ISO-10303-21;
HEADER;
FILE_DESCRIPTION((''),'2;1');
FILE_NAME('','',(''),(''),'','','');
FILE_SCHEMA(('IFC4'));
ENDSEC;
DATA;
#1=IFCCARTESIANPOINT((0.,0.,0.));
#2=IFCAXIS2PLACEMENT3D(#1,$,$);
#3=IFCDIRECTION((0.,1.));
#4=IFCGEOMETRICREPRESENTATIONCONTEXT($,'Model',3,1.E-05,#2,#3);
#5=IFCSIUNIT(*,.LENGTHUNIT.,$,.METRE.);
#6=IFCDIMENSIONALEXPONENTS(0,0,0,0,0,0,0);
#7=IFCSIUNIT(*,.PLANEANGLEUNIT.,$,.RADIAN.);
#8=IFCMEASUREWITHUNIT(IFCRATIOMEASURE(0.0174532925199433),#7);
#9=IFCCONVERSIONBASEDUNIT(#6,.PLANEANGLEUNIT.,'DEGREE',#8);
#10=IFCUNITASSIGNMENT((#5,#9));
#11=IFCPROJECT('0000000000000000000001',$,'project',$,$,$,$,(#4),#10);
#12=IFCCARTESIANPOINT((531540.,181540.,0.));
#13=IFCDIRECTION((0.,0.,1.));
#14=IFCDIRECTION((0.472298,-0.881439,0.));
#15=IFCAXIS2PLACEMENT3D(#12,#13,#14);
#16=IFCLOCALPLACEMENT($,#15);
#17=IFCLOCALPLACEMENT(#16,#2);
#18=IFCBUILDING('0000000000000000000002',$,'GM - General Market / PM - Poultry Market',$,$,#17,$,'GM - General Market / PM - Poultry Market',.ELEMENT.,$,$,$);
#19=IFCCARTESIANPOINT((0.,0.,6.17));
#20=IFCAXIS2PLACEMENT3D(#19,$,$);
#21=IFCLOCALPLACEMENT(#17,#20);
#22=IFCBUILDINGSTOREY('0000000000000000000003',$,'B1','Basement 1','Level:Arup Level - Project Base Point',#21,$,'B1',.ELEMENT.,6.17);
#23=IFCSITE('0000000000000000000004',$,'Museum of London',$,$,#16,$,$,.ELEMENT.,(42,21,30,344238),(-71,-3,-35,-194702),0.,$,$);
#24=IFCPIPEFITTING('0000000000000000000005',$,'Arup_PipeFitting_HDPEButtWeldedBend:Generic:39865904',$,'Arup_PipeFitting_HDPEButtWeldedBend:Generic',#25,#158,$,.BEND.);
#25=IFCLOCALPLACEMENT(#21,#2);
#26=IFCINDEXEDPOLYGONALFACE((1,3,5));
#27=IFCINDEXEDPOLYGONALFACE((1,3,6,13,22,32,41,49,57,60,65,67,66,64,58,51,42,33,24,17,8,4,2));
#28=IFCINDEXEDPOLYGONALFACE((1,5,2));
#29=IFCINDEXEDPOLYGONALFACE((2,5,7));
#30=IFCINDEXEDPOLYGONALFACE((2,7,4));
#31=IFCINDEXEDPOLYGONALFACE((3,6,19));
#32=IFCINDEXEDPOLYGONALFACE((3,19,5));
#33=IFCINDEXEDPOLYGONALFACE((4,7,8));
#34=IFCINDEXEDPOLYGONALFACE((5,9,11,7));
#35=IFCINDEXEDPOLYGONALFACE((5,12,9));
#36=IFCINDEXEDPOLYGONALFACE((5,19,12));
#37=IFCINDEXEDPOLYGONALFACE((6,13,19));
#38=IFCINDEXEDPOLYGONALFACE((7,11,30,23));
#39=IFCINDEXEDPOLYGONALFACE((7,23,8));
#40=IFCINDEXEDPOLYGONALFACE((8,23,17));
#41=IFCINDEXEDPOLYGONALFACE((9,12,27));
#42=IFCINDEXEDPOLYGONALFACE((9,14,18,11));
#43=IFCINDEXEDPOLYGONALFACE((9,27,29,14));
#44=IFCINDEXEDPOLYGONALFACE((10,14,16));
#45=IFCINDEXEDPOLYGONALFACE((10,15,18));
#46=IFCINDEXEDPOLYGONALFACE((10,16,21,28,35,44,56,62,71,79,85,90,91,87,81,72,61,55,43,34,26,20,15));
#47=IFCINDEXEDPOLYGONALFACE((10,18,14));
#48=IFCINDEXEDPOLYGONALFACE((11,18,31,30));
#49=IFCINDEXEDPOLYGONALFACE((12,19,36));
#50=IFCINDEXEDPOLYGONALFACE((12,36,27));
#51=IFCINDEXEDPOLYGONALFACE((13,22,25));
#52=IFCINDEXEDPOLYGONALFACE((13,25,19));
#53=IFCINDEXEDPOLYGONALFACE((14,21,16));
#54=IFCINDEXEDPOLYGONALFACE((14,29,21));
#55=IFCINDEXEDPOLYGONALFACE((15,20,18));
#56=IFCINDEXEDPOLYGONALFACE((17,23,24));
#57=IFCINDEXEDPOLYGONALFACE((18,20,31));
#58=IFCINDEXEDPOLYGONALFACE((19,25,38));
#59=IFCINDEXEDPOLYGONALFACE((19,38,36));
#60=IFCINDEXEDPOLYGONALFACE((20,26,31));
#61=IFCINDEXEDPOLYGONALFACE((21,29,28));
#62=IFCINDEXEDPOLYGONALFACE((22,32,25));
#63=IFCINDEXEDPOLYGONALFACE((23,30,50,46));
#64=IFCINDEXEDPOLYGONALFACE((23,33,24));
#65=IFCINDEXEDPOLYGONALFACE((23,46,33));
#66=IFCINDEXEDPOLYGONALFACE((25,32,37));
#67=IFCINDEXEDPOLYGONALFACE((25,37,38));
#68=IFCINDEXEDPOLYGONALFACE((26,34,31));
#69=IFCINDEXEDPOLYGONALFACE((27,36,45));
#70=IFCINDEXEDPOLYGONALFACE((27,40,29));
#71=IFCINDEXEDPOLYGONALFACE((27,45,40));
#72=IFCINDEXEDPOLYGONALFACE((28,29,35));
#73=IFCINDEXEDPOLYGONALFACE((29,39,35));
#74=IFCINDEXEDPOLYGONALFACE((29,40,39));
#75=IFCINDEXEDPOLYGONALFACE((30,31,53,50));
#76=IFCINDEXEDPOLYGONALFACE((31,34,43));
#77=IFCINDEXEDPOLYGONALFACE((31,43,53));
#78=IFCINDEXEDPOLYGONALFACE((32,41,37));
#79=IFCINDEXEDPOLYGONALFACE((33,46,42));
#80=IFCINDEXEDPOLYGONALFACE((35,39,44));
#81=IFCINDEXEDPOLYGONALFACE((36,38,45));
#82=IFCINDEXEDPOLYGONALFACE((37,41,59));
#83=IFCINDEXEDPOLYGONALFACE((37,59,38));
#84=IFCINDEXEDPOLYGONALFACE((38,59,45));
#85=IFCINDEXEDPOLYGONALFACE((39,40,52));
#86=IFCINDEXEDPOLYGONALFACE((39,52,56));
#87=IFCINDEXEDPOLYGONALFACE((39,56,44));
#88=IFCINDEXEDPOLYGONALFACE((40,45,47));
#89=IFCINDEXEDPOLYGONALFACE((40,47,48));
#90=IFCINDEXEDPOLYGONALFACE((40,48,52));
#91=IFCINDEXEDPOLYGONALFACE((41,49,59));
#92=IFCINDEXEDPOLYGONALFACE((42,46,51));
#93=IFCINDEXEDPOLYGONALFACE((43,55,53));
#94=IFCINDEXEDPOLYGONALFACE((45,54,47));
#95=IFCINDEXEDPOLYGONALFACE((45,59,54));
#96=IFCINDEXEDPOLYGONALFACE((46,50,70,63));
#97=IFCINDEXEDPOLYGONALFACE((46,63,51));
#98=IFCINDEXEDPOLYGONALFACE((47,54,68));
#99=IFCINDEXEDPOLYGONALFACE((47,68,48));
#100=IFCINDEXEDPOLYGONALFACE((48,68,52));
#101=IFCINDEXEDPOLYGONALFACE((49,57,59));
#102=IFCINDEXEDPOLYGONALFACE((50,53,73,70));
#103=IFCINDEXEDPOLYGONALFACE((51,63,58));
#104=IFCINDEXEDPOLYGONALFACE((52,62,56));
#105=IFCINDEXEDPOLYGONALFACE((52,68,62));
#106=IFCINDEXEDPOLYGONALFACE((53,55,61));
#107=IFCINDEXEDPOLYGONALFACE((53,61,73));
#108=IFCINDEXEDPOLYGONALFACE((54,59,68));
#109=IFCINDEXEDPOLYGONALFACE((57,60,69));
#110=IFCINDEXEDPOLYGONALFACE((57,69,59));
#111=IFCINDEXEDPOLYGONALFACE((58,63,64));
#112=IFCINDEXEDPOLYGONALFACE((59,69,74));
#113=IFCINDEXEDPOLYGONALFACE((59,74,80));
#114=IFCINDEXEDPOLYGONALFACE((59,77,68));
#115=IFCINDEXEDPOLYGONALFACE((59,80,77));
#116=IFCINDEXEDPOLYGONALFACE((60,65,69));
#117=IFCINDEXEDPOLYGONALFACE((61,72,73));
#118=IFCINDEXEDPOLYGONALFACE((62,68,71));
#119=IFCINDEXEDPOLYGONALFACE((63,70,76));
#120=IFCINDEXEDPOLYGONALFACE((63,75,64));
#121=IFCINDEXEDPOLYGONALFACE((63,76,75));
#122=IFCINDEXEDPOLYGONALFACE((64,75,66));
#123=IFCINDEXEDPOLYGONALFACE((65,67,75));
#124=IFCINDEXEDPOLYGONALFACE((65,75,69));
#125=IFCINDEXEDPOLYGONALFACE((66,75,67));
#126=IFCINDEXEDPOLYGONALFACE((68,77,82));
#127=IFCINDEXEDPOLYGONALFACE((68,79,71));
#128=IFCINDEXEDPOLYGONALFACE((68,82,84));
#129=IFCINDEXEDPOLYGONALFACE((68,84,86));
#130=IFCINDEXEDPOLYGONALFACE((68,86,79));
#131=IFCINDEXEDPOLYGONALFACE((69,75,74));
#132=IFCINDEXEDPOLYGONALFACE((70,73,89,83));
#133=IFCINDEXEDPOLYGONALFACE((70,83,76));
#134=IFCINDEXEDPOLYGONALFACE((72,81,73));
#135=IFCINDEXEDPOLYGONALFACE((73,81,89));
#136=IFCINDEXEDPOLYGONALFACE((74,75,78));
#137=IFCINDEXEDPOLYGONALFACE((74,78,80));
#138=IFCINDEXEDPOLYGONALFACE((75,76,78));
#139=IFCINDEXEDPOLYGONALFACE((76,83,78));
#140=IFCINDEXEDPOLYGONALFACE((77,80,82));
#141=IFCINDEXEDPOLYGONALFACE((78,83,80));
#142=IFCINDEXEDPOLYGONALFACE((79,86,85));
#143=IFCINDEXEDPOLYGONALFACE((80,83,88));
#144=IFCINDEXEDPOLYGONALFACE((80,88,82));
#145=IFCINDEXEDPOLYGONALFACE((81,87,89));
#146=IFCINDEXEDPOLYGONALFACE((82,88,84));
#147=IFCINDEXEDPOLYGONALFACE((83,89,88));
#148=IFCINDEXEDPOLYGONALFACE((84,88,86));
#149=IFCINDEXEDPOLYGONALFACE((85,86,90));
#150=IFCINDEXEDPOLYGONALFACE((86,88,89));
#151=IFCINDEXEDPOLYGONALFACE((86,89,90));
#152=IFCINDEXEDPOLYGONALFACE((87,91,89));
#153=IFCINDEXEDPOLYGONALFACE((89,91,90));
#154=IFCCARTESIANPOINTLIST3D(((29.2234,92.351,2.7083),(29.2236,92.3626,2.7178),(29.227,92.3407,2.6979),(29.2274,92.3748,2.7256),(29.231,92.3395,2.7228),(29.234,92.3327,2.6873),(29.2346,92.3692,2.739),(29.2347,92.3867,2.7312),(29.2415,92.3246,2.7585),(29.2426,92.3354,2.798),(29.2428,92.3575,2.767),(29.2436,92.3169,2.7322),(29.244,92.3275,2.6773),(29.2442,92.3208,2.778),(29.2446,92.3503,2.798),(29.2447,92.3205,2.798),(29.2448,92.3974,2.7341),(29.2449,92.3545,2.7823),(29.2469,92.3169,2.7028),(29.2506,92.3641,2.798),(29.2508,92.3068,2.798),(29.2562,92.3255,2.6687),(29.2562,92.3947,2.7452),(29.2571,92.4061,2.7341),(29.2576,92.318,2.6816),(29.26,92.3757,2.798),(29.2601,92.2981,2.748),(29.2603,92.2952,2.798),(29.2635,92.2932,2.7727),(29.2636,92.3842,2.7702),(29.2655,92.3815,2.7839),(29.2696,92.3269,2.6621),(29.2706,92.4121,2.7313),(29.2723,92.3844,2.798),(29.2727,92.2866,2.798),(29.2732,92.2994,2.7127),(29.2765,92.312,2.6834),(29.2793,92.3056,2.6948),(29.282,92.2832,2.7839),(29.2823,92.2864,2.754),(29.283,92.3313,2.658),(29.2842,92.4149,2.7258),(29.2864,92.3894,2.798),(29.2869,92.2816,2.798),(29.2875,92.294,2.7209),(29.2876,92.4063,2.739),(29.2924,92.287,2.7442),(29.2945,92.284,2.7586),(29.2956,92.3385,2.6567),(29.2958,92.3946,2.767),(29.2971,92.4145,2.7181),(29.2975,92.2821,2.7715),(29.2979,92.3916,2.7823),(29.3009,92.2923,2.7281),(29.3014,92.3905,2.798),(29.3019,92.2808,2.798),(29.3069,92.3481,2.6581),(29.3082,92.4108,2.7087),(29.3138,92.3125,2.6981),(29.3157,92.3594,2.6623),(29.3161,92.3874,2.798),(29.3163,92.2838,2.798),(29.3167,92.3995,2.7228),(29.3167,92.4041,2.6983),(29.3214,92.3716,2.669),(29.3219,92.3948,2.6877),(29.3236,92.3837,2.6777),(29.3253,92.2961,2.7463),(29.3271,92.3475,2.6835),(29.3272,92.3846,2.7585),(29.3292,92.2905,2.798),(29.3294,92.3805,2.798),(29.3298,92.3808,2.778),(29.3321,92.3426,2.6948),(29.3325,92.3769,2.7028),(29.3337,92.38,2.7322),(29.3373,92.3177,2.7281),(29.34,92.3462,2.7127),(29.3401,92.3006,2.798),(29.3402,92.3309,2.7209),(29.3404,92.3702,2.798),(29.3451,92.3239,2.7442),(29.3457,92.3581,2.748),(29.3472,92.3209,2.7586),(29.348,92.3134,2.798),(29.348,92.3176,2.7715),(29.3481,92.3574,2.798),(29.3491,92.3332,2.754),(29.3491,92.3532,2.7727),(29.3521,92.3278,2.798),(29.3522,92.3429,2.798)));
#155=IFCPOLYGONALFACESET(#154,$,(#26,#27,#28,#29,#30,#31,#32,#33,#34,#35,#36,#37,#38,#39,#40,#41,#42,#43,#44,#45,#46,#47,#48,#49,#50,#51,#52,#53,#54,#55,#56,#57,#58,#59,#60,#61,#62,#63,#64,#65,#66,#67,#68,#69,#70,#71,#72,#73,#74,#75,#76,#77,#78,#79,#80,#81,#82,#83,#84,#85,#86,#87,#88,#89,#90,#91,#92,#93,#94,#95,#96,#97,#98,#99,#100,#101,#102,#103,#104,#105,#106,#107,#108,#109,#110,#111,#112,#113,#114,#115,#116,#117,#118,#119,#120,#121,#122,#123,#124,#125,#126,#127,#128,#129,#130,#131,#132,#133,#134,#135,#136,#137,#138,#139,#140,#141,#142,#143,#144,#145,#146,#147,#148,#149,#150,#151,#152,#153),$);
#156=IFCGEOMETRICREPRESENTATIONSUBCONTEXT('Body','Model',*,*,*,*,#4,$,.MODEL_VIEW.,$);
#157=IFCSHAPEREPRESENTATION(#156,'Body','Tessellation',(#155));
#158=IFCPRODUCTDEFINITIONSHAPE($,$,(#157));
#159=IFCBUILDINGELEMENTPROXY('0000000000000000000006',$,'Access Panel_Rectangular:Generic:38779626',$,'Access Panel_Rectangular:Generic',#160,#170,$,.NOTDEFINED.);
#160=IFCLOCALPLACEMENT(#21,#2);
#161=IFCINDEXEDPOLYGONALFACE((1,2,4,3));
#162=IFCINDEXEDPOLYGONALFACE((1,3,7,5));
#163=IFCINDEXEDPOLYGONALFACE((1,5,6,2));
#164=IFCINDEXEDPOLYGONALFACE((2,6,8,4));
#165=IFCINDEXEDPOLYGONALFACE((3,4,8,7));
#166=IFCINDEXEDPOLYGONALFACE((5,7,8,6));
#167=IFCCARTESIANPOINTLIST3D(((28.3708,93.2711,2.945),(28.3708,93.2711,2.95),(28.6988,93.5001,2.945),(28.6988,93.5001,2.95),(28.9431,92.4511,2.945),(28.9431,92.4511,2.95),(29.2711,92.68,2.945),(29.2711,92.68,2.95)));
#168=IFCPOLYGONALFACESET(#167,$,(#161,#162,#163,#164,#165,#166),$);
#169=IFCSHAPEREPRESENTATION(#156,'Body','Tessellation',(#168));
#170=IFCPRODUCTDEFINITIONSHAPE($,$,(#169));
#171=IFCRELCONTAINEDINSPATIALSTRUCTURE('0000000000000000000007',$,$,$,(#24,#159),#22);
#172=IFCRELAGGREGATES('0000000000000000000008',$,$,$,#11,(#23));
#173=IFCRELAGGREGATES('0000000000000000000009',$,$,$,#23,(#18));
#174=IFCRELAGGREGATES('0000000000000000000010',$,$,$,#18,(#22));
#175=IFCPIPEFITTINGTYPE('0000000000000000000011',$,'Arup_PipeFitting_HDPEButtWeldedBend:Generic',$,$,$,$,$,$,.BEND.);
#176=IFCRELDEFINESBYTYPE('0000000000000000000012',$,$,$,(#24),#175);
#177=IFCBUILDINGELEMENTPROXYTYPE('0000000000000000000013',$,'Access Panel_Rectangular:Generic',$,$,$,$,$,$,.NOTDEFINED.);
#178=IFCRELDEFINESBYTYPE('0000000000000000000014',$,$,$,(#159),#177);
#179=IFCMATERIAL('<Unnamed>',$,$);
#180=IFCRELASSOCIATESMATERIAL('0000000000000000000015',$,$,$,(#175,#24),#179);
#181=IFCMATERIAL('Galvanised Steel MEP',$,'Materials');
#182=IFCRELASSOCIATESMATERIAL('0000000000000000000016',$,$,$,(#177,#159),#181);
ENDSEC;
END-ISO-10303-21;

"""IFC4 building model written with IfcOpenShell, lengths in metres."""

from ifc_helpers import new_model, entity, si_unit, converted_unit, direction, frame, origin, origin_2d_with_axis, place, context, subcontext, project, spatial, rectangle, extrude, source, transform, mapped, material, type_object, type_shapes, element, save


model = new_model("IFC4")

# Units and contexts
model_context = context("Model", 3, precision=1e-05, world=origin(), true_north=direction((0.0, 1.0)))
body_context = subcontext(model_context, "Body", "Model", "MODEL_VIEW")
ifc_project = project(units=[si_unit("LENGTHUNIT", "METRE"), converted_unit("PLANEANGLEUNIT", "DEGREE", entity("IfcRatioMeasure", 0.0174532925199433), si_unit("PLANEANGLEUNIT", "RADIAN"), dimensions=[0, 0, 0, 0, 0, 0, 0])], contexts=[model_context])

# Site, building, storey
site_placement = place(None, frame((531540.0, 181540.0, 0.0), z_axis=(0.0, 0.0, 1.0), x_axis=(0.472298, -0.881439, 0.0)))
site = spatial("IfcSite", under=ifc_project, at=site_placement, Name="Museum of London", CompositionType="ELEMENT", RefLatitude=(42, 21, 30, 344238), RefLongitude=(-71, -3, -35, -194702), RefElevation=0.0)
building_placement = place(site_placement, origin())
building = spatial("IfcBuilding", under=site, at=building_placement, Name="GM - General Market / PM - Poultry Market", LongName="GM - General Market / PM - Poultry Market", CompositionType="ELEMENT")
storey_placement = place(building_placement, frame((0.0, 0.0, 6.17)))
storey = spatial("IfcBuildingStorey", under=building, at=storey_placement, Name="B1", Description="Basement 1", ObjectType="Level:Arup Level - Project Base Point", LongName="B1", CompositionType="ELEMENT", Elevation=6.17)

# Shared definitions
ifc_material_1 = material(Name="Galvanised Steel MEP", Category="Materials")

# Shared definitions
ifc_material_2 = material(Name="<Unnamed>")

# Pipe fitting
pipe_fitting_type_1 = type_object("IfcPipeFittingType", Name="Arup_PipeFitting_HDPEButtWeldedBend:Generic", PredefinedType="BEND", material=ifc_material_2)
ifc_direction_1 = entity("IfcDirection", [0.0, 0.0, 1.0])
trimmed_curve_1 = entity("IfcTrimmedCurve", entity("IfcCircle", entity("IfcAxis2Placement2D", entity("IfcCartesianPoint", [-0.1449, 0.0]), entity("IfcDirection", [0.0, 1.0])), 0.1449), [entity("IfcParameterValue", 270.0)], [entity("IfcParameterValue", 315.0)], True, "PARAMETER")
shared_shape_1 = source(origin(), body_context, "Body", "AdvancedSweptSolid", [
    entity("IfcSurfaceCurveSweptAreaSolid", entity("IfcCircleProfileDef", "AREA", None, entity("IfcAxis2Placement2D", entity("IfcCartesianPoint", [0.0, 0.0]), entity("IfcDirection", [1.0, 0.0])), 0.055), entity("IfcAxis2Placement3D", entity("IfcCartesianPoint", [-0.06, 0.0, 0.0]), ifc_direction_1, entity("IfcDirection", [0.0, -1.0, 0.0])), trimmed_curve_1, 0.0, 45.0, entity("IfcSurfaceOfLinearExtrusion", entity("IfcArbitraryOpenProfileDef", "CURVE", None, trimmed_curve_1), entity("IfcAxis2Placement3D", entity("IfcCartesianPoint", [0.0, 0.0, -0.3048])), ifc_direction_1, 1.0)),
])
type_shapes(pipe_fitting_type_1, [shared_shape_1])
for number, where, z_axis, x_axis, name in (
    (1, (29.2976, 92.3356, 2.738), (-0.819074, -0.573689, 0.0), (0.405659, -0.579172, 0.707107), "Arup_PipeFitting_HDPEButtWeldedBend:Generic:39865904"),
):
    element("IfcPipeFitting", number, at=place(storey_placement, frame(where, z_axis=z_axis, x_axis=x_axis)), inside=storey, type_object=pipe_fitting_type_1, material=ifc_material_2, Name=name, ObjectType="Arup_PipeFitting_HDPEButtWeldedBend:Generic", PredefinedType="BEND", context=body_context, shape_type="MappedRepresentation", body=[
        mapped(shared_shape_1, transform((0.0, 0.0, 0.0), scale=1.0)),
    ])

# Building element proxy
building_element_proxy_type = type_object("IfcBuildingElementProxyType", Name="Access Panel_Rectangular:Generic", PredefinedType="NOTDEFINED", material=ifc_material_1)
shared_shape_2 = source(origin(), body_context, "Body", "SweptSolid", [
    extrude(rectangle(XDim=0.4, YDim=1.0, at=origin_2d_with_axis()), frame((0.0, 0.0, -0.005), z_axis=(0.0, 0.0, 1.0), x_axis=(-1.0, 0.0, 0.0)), (0.0, 0.0, 1.0), 0.005),
])
type_shapes(building_element_proxy_type, [shared_shape_2])
proxy_placement = place(storey_placement, frame((28.821, 92.9756, 2.95), z_axis=(0.0, 0.0, 1.0), x_axis=(-0.820027, -0.572325, 0.0)))
element("IfcBuildingElementProxy", 2, at=proxy_placement, inside=storey, type_object=building_element_proxy_type, material=ifc_material_1, Name="Access Panel_Rectangular:Generic:38779626", ObjectType="Access Panel_Rectangular:Generic", PredefinedType="NOTDEFINED", context=body_context, shape_type="MappedRepresentation", body=[
    mapped(shared_shape_2, transform((0.0, 0.0, 0.0), scale=1.0)),
])

save(model, "model.ifc")
